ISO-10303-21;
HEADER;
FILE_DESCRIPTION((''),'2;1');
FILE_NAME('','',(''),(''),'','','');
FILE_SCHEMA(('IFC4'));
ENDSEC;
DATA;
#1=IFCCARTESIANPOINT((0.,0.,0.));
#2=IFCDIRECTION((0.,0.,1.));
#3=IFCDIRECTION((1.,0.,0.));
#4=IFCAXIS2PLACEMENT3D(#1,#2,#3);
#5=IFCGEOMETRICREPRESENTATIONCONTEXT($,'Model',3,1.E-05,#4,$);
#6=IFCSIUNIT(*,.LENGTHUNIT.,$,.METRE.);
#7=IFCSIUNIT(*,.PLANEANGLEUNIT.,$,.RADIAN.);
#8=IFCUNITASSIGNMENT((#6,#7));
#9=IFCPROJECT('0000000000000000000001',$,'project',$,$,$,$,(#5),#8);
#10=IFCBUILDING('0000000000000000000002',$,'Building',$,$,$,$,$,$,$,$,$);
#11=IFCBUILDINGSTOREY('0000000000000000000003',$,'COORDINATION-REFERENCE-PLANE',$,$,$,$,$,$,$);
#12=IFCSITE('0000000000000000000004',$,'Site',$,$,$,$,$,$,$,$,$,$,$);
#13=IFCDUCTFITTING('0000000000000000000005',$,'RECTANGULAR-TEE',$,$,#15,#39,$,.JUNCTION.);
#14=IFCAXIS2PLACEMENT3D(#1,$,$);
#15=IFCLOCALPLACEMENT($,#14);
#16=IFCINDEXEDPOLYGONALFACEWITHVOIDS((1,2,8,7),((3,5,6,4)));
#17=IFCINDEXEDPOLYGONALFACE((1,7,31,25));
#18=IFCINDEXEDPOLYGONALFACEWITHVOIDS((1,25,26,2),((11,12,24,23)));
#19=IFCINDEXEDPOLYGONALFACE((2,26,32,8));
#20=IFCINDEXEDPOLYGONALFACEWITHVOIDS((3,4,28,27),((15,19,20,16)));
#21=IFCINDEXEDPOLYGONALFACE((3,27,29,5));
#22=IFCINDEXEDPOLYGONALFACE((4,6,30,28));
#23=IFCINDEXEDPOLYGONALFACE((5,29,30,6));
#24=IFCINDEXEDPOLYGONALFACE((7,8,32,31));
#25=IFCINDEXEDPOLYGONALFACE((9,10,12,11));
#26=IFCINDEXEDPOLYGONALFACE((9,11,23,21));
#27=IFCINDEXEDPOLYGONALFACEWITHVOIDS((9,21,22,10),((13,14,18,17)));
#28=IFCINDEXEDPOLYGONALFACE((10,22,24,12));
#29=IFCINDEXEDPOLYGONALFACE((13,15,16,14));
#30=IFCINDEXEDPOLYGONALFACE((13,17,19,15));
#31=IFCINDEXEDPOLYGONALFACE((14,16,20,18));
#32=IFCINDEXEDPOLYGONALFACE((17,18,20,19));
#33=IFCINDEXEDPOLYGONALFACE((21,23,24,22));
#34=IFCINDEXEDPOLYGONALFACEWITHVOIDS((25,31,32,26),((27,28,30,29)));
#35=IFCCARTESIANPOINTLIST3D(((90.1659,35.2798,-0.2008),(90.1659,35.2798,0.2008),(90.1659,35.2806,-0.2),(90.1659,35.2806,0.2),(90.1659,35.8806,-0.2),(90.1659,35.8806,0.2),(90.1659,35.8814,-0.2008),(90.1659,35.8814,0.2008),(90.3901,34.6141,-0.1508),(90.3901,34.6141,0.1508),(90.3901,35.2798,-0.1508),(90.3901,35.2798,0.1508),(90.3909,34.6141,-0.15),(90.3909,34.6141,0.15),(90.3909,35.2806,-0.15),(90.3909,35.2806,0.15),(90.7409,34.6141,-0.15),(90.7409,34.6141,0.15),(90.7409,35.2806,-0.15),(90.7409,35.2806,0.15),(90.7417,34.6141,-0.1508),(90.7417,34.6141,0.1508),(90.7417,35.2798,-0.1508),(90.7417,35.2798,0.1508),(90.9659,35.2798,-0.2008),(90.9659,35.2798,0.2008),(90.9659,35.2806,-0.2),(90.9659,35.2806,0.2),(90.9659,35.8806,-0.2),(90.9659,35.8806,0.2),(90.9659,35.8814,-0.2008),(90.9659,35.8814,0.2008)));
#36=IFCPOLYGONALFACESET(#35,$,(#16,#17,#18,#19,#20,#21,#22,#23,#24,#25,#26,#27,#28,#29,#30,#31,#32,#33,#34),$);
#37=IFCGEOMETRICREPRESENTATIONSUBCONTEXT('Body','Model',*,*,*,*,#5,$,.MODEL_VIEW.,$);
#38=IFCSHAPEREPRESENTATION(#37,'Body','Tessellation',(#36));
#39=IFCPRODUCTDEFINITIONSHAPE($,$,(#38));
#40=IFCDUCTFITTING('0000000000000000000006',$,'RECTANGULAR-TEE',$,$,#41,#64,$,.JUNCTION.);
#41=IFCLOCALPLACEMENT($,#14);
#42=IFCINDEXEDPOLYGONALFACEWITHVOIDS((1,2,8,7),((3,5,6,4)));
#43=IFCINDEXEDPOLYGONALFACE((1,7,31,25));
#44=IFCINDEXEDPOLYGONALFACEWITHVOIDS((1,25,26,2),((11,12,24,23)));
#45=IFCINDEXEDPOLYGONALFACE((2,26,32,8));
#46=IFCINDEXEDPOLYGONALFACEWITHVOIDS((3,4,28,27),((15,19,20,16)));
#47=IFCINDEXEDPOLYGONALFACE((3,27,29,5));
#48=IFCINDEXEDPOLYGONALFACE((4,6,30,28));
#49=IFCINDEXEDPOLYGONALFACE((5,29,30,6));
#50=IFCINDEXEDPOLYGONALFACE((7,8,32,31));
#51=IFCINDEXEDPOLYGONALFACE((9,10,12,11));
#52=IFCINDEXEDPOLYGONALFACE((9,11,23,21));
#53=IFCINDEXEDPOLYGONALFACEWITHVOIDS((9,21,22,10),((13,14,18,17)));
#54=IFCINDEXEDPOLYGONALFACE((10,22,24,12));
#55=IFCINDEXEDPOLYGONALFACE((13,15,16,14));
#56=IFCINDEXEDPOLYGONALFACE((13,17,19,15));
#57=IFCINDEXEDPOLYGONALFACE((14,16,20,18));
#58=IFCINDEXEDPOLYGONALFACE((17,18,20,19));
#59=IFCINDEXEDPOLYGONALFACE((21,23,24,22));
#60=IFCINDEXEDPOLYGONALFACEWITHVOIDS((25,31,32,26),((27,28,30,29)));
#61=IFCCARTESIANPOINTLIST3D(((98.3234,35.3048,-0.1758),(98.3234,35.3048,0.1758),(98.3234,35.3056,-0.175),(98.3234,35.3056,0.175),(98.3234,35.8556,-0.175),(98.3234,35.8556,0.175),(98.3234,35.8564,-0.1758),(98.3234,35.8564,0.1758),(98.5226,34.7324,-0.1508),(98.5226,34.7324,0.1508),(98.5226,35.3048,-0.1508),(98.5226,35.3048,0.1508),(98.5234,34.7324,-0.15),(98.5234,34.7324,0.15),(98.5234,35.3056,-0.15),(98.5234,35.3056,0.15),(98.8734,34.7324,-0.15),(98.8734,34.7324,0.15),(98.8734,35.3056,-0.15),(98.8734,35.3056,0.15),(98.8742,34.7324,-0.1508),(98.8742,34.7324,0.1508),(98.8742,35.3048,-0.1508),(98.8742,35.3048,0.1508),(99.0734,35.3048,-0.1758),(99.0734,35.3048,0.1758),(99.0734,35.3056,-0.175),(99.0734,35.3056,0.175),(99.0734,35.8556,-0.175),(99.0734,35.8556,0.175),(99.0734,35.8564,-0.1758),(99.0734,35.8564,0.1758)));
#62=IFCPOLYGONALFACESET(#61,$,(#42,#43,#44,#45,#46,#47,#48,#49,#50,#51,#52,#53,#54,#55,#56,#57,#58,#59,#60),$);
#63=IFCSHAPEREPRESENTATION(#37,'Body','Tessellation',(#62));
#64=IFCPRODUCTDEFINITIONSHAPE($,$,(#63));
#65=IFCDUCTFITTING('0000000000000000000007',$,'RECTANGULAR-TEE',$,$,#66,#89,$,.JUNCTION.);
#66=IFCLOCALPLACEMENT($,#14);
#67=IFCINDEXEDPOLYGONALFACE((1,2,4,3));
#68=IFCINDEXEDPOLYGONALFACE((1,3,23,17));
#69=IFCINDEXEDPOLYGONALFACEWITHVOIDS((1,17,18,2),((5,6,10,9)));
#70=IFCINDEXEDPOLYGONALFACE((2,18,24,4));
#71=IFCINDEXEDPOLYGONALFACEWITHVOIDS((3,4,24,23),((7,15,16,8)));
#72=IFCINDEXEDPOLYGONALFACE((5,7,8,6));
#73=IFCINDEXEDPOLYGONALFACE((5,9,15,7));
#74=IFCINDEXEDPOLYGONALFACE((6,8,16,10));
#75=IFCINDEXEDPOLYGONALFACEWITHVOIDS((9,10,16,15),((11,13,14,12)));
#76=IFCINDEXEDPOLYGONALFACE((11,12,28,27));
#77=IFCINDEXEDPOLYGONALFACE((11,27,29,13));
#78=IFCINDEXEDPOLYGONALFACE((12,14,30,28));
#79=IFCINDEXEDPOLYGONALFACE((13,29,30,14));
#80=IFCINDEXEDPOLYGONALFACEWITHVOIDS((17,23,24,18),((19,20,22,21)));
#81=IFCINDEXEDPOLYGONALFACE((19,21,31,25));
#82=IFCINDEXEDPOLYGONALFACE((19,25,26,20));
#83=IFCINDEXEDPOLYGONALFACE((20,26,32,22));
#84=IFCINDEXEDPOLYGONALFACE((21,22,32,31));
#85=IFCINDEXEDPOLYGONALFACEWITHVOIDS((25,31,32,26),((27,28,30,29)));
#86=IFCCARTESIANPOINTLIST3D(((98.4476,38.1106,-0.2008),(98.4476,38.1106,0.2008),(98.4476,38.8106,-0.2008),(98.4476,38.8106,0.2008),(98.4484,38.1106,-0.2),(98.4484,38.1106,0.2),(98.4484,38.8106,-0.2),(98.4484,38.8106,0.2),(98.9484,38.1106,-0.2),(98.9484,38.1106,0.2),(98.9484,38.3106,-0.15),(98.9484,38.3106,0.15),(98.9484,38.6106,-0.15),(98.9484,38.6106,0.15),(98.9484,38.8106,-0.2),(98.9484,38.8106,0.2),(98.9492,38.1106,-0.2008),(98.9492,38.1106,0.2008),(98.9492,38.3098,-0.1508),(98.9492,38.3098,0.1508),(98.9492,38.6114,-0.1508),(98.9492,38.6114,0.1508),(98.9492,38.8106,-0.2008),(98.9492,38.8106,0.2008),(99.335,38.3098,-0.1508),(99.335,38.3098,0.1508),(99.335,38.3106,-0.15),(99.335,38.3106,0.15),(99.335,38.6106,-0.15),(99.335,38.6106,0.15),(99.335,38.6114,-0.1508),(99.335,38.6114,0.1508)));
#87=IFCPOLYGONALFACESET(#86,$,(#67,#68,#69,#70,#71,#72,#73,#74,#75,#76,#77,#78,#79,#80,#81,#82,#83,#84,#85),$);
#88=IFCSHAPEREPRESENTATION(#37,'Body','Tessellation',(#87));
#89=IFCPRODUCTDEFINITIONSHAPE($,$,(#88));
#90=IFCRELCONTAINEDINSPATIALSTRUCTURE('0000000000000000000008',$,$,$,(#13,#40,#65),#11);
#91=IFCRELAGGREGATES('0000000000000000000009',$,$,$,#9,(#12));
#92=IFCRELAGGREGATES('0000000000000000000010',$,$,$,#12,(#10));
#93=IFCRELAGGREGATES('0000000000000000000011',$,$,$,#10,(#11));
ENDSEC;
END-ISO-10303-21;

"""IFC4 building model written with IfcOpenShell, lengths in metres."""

from ifc_helpers import new_model, si_unit, frame, origin_with_axes, place, context, subcontext, project, spatial, rectangle, extrude, boolean, element, save


model = new_model("IFC4")

# Units and contexts
model_context = context("Model", 3, precision=1e-05, world=origin_with_axes())
body_context = subcontext(model_context, "Body", "Model", "MODEL_VIEW")
ifc_project = project(units=[si_unit("LENGTHUNIT", "METRE"), si_unit("PLANEANGLEUNIT", "RADIAN")], contexts=[model_context])

# Site, building, storey
site = spatial("IfcSite", under=ifc_project, Name="Site")
building = spatial("IfcBuilding", under=site, Name="Building")
storey = spatial("IfcBuildingStorey", under=building, Name="COORDINATION-REFERENCE-PLANE")

# Duct fittings
duct_fitting_1_placement = place(None, frame((90.5659, 35.5806, 0.0), z_axis=(1.0, 0.0, 0.0), x_axis=(0.0, -1.0, 0.0)))
solid_1 = boolean("UNION", extrude(rectangle(XDim=0.6, YDim=0.4), frame((0.0, 0.0, -0.4), z_axis=(0.0, 0.0, 1.0), x_axis=(1.0, 0.0, 0.0)), (0.0, 0.0, 1.0), 0.8), extrude(rectangle(XDim=0.35, YDim=0.3), frame((0.0, 0.0, 0.0), z_axis=(1.0, 0.0, 0.0), x_axis=(0.0, 0.0, -1.0)), (0.0, 0.0, 1.0), 0.9665))
element("IfcDuctFitting", 1, at=duct_fitting_1_placement, inside=storey, Name="RECTANGULAR-TEE", PredefinedType="JUNCTION", context=body_context, shape_type="CSG", body=[
    boolean("DIFFERENCE", boolean("UNION", extrude(rectangle(XDim=0.6016, YDim=0.4016), frame((0.0, 0.0, -0.4), z_axis=(0.0, 0.0, 1.0), x_axis=(1.0, 0.0, 0.0)), (0.0, 0.0, 1.0), 0.8), extrude(rectangle(XDim=0.3516, YDim=0.3016), frame((0.0, 0.0, 0.0), z_axis=(1.0, 0.0, 0.0), x_axis=(0.0, 0.0, -1.0)), (0.0, 0.0, 1.0), 0.9665)), solid_1),
])
duct_fitting_2_placement = place(None, frame((98.6984, 35.5806, 0.0), z_axis=(1.0, 0.0, 0.0), x_axis=(0.0, -1.0, 0.0)))
solid_2 = boolean("UNION", extrude(rectangle(XDim=0.55, YDim=0.35), frame((0.0, 0.0, -0.375), z_axis=(0.0, 0.0, 1.0), x_axis=(1.0, 0.0, 0.0)), (0.0, 0.0, 1.0), 0.75), extrude(rectangle(XDim=0.35, YDim=0.3), frame((0.0, 0.0, 0.0), z_axis=(1.0, 0.0, 0.0), x_axis=(0.0, 0.0, -1.0)), (0.0, 0.0, 1.0), 0.8482))
element("IfcDuctFitting", 2, at=duct_fitting_2_placement, inside=storey, Name="RECTANGULAR-TEE", PredefinedType="JUNCTION", context=body_context, shape_type="CSG", body=[
    boolean("DIFFERENCE", boolean("UNION", extrude(rectangle(XDim=0.5516, YDim=0.3516), frame((0.0, 0.0, -0.375), z_axis=(0.0, 0.0, 1.0), x_axis=(1.0, 0.0, 0.0)), (0.0, 0.0, 1.0), 0.75), extrude(rectangle(XDim=0.3516, YDim=0.3016), frame((0.0, 0.0, 0.0), z_axis=(1.0, 0.0, 0.0), x_axis=(0.0, 0.0, -1.0)), (0.0, 0.0, 1.0), 0.8482)), solid_2),
])
duct_fitting_3_placement = place(None, frame((98.6984, 38.4606, 0.0), z_axis=(0.0, 1.0, 0.0), x_axis=(1.0, 0.0, 0.0)))
solid_3 = boolean("UNION", extrude(rectangle(XDim=0.5, YDim=0.4), frame((0.0, 0.0, -0.35), z_axis=(0.0, 0.0, 1.0), x_axis=(1.0, 0.0, 0.0)), (0.0, 0.0, 1.0), 0.7), extrude(rectangle(XDim=0.3, YDim=0.3), frame((0.0, 0.0, 0.0), z_axis=(1.0, 0.0, 0.0), x_axis=(0.0, 0.0, -1.0)), (0.0, 0.0, 1.0), 0.6366))
element("IfcDuctFitting", 3, at=duct_fitting_3_placement, inside=storey, Name="RECTANGULAR-TEE", PredefinedType="JUNCTION", context=body_context, shape_type="CSG", body=[
    boolean("DIFFERENCE", boolean("UNION", extrude(rectangle(XDim=0.5016, YDim=0.4016), frame((0.0, 0.0, -0.35), z_axis=(0.0, 0.0, 1.0), x_axis=(1.0, 0.0, 0.0)), (0.0, 0.0, 1.0), 0.7), extrude(rectangle(XDim=0.3016, YDim=0.3016), frame((0.0, 0.0, 0.0), z_axis=(1.0, 0.0, 0.0), x_axis=(0.0, 0.0, -1.0)), (0.0, 0.0, 1.0), 0.6366)), solid_3),
])

save(model, "model.ifc")
